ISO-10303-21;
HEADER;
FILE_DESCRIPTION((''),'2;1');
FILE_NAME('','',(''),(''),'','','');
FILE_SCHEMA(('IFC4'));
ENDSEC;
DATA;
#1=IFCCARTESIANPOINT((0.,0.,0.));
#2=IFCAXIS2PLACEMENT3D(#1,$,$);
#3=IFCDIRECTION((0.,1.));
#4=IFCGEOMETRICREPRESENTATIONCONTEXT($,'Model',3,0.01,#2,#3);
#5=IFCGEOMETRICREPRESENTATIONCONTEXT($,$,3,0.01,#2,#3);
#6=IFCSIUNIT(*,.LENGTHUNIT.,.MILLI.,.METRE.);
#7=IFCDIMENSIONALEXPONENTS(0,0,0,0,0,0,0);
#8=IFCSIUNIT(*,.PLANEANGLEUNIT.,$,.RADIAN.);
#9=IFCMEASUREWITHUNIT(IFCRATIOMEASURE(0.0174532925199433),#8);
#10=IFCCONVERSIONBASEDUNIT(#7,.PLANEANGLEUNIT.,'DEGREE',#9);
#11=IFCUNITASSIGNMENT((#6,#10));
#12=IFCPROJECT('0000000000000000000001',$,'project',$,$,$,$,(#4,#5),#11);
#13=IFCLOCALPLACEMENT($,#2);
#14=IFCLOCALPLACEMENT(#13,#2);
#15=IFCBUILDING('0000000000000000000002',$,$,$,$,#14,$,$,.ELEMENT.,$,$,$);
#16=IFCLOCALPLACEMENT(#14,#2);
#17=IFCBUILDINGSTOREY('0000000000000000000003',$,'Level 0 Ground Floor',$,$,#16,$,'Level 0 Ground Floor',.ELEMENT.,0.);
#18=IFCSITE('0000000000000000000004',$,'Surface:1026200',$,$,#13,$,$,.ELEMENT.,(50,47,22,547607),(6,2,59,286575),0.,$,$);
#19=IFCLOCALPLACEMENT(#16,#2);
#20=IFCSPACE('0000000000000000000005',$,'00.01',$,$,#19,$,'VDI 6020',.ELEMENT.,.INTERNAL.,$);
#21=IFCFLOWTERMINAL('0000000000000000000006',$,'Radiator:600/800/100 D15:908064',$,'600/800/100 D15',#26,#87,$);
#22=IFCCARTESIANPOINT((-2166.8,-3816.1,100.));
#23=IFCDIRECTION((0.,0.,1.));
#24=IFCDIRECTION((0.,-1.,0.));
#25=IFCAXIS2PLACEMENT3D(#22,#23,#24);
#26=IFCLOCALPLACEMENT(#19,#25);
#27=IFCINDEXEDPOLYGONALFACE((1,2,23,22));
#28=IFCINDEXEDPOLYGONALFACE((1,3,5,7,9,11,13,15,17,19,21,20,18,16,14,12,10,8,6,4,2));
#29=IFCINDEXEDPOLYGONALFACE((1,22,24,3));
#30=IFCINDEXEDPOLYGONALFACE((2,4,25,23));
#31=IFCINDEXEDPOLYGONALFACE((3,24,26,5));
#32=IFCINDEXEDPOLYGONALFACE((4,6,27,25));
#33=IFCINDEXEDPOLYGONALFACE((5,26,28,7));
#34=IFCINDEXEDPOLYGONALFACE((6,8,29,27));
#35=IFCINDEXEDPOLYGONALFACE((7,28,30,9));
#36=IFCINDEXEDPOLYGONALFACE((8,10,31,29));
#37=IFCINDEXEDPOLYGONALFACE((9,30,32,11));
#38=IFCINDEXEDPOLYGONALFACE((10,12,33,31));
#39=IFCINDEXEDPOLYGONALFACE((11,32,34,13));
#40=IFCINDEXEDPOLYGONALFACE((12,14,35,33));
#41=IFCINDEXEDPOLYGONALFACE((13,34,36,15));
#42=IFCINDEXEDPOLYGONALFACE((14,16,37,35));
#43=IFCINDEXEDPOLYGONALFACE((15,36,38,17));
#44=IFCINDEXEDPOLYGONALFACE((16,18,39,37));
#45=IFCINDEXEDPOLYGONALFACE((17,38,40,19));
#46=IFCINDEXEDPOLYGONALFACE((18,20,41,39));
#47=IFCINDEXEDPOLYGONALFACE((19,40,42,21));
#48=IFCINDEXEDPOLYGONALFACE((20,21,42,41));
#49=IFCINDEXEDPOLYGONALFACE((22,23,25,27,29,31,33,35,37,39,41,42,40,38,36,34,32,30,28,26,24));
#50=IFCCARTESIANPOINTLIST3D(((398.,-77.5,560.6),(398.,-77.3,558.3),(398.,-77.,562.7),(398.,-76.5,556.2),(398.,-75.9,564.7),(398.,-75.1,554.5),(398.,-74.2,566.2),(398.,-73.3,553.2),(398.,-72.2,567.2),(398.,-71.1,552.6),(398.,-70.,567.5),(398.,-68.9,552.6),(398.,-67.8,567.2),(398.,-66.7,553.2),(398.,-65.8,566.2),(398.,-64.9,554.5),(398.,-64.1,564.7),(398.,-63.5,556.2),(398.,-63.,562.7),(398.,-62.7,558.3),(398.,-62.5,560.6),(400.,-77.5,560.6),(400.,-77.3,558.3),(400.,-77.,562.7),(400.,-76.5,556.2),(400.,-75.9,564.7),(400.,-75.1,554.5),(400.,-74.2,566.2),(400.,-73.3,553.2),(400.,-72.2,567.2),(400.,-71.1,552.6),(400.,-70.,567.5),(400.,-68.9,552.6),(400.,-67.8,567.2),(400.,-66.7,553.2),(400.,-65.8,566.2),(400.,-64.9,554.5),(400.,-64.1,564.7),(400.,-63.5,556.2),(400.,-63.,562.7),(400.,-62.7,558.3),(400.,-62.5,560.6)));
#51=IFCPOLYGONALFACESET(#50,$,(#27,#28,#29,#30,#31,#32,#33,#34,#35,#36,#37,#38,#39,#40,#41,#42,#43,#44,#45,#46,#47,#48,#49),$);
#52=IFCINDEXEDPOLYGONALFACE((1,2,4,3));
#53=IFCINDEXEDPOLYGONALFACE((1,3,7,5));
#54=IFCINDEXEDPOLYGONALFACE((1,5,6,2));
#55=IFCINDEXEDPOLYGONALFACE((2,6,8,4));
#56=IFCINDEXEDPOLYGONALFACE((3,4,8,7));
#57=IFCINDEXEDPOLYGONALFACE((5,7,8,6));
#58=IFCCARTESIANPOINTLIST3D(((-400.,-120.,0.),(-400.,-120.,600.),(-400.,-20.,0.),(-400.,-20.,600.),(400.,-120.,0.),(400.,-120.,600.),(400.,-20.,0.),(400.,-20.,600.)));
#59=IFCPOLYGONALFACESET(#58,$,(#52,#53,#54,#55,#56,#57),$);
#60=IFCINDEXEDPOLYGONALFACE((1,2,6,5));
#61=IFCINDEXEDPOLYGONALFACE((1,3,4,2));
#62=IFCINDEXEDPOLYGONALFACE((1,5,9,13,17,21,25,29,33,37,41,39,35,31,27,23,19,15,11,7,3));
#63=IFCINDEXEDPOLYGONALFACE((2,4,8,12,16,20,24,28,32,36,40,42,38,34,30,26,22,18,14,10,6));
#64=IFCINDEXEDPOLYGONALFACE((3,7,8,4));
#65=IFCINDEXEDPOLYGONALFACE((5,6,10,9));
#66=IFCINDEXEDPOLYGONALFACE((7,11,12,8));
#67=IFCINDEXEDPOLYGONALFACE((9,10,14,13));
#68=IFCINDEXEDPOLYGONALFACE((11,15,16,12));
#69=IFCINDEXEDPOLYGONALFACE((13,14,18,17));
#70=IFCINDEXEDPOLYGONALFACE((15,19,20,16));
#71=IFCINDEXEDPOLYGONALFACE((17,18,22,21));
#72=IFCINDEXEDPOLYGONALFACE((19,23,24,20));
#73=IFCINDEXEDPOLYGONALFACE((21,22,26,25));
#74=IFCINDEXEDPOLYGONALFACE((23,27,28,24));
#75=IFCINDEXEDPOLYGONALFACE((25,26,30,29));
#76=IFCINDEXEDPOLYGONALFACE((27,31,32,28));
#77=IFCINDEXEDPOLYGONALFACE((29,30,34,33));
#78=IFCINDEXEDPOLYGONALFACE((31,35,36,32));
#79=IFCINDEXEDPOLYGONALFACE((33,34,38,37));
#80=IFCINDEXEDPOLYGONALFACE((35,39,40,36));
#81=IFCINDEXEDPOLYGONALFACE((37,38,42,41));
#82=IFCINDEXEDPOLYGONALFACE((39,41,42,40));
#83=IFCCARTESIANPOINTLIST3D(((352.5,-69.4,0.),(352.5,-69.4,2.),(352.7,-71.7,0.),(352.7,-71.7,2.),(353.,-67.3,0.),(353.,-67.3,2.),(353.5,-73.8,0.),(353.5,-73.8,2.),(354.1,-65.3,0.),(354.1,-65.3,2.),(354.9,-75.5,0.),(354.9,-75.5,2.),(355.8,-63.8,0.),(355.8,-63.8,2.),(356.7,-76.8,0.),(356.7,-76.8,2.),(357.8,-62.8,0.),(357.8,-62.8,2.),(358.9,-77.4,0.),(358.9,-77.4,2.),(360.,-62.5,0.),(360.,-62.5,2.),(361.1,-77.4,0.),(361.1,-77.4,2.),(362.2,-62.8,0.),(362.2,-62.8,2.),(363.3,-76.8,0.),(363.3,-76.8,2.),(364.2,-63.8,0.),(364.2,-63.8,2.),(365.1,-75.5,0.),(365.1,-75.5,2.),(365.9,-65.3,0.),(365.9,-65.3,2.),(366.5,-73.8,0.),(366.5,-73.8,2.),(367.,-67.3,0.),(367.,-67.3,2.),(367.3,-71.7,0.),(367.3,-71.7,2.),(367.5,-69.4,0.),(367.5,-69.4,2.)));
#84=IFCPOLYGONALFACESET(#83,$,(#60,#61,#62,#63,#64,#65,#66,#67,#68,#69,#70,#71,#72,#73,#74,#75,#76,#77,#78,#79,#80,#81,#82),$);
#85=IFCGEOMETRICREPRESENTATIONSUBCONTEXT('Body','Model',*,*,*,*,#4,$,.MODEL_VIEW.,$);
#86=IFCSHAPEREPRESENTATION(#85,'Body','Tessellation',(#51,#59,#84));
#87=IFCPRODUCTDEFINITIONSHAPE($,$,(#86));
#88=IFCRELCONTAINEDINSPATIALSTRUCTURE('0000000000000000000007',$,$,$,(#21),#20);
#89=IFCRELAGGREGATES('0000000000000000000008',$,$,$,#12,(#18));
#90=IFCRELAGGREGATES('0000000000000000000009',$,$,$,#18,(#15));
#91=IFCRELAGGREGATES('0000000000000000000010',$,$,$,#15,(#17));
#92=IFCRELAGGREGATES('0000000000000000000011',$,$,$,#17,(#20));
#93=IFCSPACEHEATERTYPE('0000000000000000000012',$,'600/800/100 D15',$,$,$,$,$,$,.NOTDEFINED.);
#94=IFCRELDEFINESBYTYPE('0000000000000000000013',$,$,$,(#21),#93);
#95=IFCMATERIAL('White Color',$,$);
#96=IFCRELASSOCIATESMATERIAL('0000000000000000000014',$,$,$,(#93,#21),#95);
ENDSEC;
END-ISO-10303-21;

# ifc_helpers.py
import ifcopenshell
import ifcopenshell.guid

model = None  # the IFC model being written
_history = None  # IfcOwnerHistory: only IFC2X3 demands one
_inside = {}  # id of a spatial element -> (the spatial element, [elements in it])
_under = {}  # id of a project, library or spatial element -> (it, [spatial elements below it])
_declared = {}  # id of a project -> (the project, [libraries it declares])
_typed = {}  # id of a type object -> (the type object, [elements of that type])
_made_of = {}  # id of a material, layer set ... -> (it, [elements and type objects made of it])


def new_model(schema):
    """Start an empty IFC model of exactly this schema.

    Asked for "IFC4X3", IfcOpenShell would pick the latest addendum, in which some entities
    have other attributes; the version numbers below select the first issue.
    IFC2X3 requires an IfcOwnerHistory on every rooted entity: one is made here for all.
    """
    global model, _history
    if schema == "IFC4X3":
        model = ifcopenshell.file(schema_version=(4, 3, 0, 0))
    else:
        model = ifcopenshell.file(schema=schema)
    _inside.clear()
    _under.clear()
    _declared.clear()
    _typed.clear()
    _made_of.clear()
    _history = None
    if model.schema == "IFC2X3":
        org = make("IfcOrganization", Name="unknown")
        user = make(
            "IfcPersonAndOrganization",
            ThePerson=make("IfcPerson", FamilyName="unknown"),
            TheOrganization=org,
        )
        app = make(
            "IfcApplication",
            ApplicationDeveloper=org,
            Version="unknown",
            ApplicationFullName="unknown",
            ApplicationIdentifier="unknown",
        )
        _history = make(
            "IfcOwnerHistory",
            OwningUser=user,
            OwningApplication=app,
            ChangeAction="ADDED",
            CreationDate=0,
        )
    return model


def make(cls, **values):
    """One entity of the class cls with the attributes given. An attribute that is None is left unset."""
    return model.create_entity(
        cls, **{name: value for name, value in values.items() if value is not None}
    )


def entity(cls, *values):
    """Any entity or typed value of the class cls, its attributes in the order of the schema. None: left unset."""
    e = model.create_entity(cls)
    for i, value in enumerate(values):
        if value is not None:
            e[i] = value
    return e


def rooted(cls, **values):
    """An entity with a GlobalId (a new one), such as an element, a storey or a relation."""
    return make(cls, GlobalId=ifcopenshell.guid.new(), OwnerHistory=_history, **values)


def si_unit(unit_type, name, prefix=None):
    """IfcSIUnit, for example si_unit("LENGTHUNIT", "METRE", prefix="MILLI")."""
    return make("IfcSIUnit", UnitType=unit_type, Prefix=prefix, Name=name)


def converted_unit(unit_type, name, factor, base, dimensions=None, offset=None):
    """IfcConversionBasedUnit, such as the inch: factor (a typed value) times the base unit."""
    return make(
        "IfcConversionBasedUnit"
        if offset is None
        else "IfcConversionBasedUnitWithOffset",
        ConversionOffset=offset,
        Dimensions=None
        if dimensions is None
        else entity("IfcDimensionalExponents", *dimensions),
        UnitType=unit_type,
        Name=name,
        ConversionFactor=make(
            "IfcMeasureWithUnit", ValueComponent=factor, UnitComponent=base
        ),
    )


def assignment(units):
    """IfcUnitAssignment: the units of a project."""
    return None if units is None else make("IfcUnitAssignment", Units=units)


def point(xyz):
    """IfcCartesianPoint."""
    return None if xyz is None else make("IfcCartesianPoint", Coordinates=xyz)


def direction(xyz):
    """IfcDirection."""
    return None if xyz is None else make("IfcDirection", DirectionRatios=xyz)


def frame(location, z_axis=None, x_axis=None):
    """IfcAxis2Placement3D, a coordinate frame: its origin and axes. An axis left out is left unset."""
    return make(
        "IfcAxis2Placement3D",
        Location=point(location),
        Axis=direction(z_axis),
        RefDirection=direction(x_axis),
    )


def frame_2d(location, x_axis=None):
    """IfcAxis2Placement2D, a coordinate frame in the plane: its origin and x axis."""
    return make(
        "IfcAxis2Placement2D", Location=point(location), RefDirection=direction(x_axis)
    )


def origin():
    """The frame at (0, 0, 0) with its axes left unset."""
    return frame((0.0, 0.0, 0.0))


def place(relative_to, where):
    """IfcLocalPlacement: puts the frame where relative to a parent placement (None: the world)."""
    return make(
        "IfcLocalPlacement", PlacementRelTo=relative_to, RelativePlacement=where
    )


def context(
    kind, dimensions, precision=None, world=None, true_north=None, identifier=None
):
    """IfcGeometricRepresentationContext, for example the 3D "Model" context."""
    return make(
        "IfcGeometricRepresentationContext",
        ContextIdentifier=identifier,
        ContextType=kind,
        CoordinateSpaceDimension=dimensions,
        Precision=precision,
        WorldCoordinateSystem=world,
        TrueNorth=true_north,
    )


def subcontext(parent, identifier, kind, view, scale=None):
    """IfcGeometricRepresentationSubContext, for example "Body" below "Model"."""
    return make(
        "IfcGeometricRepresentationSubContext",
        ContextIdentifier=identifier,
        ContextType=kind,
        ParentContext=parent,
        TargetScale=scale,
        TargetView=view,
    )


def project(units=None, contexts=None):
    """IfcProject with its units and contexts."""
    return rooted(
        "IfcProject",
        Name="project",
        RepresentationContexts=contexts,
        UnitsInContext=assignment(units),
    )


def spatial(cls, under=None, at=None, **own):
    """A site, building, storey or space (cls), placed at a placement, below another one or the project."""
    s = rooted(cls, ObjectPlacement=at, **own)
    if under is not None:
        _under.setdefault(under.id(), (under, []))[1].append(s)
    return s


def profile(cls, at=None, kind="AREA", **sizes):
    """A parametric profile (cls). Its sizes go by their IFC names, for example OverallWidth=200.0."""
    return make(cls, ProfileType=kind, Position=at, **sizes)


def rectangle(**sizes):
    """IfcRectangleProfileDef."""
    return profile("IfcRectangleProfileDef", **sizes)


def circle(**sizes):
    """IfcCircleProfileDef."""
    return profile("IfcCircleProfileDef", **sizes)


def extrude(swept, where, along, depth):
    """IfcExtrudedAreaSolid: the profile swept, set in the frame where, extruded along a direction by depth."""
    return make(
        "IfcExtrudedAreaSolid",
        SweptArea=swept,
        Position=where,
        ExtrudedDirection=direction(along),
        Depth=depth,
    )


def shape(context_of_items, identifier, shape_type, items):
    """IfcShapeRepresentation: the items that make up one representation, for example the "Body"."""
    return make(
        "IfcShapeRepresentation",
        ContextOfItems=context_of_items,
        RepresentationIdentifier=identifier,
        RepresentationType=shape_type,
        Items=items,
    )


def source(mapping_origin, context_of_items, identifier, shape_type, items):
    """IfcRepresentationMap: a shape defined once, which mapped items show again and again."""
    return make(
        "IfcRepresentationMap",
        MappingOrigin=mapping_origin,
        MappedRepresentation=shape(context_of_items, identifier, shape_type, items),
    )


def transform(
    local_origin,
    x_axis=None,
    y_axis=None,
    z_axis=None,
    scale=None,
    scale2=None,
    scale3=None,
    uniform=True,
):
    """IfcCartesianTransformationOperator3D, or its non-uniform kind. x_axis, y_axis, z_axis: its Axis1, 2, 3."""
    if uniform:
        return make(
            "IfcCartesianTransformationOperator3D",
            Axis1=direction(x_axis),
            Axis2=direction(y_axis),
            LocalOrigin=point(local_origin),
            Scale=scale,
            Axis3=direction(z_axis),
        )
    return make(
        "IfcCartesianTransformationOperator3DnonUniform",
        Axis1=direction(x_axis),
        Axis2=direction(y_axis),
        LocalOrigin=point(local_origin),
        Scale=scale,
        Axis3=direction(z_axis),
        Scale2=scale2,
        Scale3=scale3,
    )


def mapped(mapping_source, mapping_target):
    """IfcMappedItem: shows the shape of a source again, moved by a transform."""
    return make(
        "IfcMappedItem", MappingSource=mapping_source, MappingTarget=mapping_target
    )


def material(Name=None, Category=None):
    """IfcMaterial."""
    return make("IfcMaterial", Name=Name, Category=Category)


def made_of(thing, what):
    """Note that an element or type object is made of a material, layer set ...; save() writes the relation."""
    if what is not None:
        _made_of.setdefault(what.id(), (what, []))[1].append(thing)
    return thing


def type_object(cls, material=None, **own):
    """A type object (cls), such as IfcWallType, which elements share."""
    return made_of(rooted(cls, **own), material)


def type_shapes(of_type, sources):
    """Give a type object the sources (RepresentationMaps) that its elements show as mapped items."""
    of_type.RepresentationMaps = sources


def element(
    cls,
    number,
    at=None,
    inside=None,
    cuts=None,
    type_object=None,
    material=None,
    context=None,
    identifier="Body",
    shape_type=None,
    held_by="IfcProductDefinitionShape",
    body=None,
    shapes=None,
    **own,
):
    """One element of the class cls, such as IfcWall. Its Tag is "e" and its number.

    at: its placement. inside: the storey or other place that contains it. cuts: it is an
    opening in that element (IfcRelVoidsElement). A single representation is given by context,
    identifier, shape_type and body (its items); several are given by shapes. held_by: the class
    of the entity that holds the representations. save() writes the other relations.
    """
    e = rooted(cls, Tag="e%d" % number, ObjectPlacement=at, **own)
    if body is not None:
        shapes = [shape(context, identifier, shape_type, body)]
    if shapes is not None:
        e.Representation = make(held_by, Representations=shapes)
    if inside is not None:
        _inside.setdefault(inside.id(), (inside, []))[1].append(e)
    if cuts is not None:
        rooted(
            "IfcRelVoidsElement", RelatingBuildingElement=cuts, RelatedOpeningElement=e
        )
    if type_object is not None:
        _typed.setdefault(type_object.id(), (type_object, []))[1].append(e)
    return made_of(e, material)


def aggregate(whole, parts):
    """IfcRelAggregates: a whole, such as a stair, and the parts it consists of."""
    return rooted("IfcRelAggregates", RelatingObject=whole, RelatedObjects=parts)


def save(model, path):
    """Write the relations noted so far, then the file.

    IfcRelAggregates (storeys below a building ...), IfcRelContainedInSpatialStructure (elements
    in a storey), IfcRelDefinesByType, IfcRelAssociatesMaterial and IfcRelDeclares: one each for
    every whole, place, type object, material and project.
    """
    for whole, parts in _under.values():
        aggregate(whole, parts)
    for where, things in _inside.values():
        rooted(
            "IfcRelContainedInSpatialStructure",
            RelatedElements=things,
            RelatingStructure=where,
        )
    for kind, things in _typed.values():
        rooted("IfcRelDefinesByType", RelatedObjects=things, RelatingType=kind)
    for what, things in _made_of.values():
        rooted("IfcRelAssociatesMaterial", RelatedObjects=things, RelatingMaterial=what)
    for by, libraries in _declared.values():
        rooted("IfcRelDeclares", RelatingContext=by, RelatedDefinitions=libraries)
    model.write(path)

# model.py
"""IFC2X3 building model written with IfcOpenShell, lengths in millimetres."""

from ifc_helpers import new_model, entity, si_unit, converted_unit, direction, frame, frame_2d, origin, place, context, subcontext, project, spatial, rectangle, circle, extrude, source, transform, mapped, material, type_object, type_shapes, element, save


model = new_model("IFC2X3")

# Units and contexts
model_context = context("Model", 3, precision=0.01, world=origin(), true_north=direction((0.0, 1.0)))
context_of_model = context(None, 3, precision=0.01, world=origin(), true_north=direction((0.0, 1.0)))
body_context = subcontext(model_context, "Body", "Model", "MODEL_VIEW")
ifc_project = project(units=[si_unit("LENGTHUNIT", "METRE", prefix="MILLI"), converted_unit("PLANEANGLEUNIT", "DEGREE", entity("IfcRatioMeasure", 0.0174532925199433), si_unit("PLANEANGLEUNIT", "RADIAN"), dimensions=[0, 0, 0, 0, 0, 0, 0])], contexts=[model_context, context_of_model])

# Site, building, storey
site_placement = place(None, origin())
site = spatial("IfcSite", under=ifc_project, at=site_placement, Name="Surface:1026200", CompositionType="ELEMENT", RefLatitude=(50, 47, 22, 547607), RefLongitude=(6, 2, 59, 286575), RefElevation=0.0)
building_placement = place(site_placement, origin())
building = spatial("IfcBuilding", under=site, at=building_placement, CompositionType="ELEMENT")
storey_placement = place(building_placement, origin())
storey = spatial("IfcBuildingStorey", under=building, at=storey_placement, Name="Level 0 Ground Floor", LongName="Level 0 Ground Floor", CompositionType="ELEMENT", Elevation=0.0)

# Shared definitions
space_placement = place(storey_placement, origin())
space = spatial("IfcSpace", under=storey, at=space_placement, Name="00.01", LongName="VDI 6020", CompositionType="ELEMENT", InteriorOrExteriorSpace="INTERNAL")

# Flow terminal
ifc_material_1 = material(Name="White Color")
space_heater_type = type_object("IfcSpaceHeaterType", Name="600/800/100 D15", PredefinedType="SECTIONALRADIATOR", material=ifc_material_1)
shared_shape_1 = source(origin(), body_context, "Body", "SweptSolid", [
    extrude(circle(Radius=7.5, at=frame_2d((0.0, 0.0), x_axis=(1.0, 0.0))), frame((398.0, -70.0, 560.0), z_axis=(1.0, 0.0, 0.0), x_axis=(0.0, 0.0, 1.0)), (0.0, 0.0, 1.0), 2.0),
    extrude(rectangle(XDim=100.0, YDim=800.0, at=frame_2d((0.0, 0.0), x_axis=(1.0, 0.0))), frame((0.0, -70.0, 0.0), z_axis=(0.0, 0.0, 1.0), x_axis=(0.0, 1.0, 0.0)), (0.0, 0.0, 1.0), 600.0),
    extrude(circle(Radius=7.5, at=frame_2d((0.0, 0.0), x_axis=(1.0, 0.0))), frame((360.0, -70.0, 0.0), z_axis=(0.0, 0.0, 1.0), x_axis=(0.0, 1.0, 0.0)), (0.0, 0.0, 1.0), 2.0),
])
type_shapes(space_heater_type, [shared_shape_1])
flow_terminal_placement = place(space_placement, frame((-2166.8, -3816.1, 100.0), z_axis=(0.0, 0.0, 1.0), x_axis=(0.0, -1.0, 0.0)))
element("IfcFlowTerminal", 1, at=flow_terminal_placement, inside=space, type_object=space_heater_type, material=ifc_material_1, Name="Radiator:600/800/100 D15:908064", ObjectType="600/800/100 D15", context=body_context, shape_type="MappedRepresentation", body=[
    mapped(shared_shape_1, transform((0.0, 0.0, 0.0), scale=1.0)),
])

save(model, "model.ifc")
